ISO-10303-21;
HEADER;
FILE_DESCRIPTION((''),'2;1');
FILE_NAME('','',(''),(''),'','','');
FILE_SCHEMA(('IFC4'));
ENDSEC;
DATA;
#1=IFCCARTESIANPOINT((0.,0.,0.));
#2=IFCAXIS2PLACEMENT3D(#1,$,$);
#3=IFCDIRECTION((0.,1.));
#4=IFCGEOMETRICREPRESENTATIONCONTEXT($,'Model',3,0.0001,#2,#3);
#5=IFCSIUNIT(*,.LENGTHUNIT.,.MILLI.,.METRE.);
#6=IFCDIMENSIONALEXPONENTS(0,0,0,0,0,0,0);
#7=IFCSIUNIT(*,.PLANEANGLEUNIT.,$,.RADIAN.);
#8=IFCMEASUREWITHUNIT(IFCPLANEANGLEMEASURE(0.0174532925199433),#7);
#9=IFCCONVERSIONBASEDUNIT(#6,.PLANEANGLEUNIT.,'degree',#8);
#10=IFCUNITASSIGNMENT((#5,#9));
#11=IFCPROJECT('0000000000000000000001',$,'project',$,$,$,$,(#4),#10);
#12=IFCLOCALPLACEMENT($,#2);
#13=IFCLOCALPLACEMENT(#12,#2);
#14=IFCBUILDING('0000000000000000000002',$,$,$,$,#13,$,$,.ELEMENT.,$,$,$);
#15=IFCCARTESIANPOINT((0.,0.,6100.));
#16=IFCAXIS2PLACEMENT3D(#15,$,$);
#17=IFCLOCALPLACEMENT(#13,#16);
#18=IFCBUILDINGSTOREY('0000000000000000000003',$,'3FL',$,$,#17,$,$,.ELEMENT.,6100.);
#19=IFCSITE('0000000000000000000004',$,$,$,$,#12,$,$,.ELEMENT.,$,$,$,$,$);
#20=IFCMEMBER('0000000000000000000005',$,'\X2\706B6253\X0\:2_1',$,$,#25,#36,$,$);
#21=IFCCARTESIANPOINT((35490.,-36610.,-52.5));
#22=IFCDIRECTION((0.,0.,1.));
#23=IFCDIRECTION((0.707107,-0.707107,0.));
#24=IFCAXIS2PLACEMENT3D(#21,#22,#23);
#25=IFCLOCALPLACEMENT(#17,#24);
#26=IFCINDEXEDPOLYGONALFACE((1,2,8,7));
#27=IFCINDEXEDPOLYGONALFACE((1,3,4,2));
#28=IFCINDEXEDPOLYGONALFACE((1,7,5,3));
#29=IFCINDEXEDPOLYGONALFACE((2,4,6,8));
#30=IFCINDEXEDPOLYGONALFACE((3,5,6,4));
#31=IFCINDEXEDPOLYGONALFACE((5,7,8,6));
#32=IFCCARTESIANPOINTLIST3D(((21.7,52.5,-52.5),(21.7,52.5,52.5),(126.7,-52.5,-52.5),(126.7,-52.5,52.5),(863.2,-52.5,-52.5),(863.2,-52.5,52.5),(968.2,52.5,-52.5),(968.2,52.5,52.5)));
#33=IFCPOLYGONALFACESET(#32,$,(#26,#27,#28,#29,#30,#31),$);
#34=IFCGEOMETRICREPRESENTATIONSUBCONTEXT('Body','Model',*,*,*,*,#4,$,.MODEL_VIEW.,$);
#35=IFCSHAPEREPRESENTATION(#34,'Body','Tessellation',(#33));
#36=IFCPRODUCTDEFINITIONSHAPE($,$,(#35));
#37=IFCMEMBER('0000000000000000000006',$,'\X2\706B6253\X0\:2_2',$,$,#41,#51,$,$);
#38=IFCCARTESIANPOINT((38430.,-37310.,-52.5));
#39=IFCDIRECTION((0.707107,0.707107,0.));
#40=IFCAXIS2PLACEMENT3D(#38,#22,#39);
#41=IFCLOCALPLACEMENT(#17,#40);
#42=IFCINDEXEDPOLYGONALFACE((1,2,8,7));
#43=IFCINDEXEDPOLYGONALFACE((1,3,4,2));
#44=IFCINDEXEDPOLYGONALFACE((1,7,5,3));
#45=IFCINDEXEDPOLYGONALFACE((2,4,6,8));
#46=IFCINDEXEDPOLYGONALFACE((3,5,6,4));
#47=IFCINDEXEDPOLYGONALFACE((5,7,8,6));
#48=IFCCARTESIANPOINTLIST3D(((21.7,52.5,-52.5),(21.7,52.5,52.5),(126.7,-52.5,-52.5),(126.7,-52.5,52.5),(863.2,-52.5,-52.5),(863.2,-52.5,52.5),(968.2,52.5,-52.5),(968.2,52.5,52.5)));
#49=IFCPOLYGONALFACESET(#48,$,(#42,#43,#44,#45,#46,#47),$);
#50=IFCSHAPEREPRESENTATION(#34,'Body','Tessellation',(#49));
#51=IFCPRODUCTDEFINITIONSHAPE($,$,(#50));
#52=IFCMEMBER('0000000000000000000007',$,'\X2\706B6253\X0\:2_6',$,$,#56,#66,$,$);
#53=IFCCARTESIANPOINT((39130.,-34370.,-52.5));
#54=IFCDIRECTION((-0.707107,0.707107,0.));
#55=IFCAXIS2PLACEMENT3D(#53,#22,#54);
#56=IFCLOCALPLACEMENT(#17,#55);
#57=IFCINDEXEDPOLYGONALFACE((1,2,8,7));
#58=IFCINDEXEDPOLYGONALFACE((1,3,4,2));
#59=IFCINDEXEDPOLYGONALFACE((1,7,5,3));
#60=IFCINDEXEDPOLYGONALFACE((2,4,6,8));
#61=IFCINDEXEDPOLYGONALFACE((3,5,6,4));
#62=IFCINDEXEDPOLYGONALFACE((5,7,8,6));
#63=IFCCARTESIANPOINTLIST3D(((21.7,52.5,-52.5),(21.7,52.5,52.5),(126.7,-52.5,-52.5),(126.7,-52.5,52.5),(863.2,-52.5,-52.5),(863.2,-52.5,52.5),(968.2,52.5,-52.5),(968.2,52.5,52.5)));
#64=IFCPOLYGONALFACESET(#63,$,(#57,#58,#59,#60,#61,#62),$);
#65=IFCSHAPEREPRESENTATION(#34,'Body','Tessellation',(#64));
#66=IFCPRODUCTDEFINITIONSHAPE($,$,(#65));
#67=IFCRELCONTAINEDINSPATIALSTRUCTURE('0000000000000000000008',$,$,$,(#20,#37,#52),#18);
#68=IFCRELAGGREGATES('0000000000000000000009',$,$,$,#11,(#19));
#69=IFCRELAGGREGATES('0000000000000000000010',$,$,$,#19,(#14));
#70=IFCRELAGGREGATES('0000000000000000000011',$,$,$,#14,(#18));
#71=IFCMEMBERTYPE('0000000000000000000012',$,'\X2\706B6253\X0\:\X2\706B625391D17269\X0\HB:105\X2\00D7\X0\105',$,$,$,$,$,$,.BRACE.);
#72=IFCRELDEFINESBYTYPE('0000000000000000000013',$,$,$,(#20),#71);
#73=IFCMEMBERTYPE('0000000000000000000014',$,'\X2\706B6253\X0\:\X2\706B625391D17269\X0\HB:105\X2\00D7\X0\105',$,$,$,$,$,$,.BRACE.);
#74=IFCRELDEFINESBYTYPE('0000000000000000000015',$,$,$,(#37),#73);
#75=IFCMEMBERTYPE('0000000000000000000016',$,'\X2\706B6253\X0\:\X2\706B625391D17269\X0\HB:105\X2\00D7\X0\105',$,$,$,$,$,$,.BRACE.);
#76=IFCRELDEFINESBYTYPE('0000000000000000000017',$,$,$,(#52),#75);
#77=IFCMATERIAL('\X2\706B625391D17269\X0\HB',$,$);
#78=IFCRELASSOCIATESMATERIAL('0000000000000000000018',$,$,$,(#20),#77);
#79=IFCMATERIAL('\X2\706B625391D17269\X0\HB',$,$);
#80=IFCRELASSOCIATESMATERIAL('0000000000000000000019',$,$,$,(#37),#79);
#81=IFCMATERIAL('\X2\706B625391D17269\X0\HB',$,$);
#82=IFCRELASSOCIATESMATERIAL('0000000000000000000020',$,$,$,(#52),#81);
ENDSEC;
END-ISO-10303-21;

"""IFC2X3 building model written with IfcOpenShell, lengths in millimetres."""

from ifc_helpers import new_model, entity, si_unit, converted_unit, direction, frame, origin, place, context, subcontext, project, spatial, polyline, outline, extrude, material, type_object, element, save


model = new_model("IFC2X3")

# Units and contexts
model_context = context("Model", 3, precision=0.0001, world=origin(), true_north=direction((0.0, 1.0)))
body_context = subcontext(model_context, "Body", "Model", "MODEL_VIEW")
ifc_project = project(units=[si_unit("LENGTHUNIT", "METRE", prefix="MILLI"), converted_unit("PLANEANGLEUNIT", "degree", entity("IfcPlaneAngleMeasure", 0.0174532925199433), si_unit("PLANEANGLEUNIT", "RADIAN"), dimensions=[0, 0, 0, 0, 0, 0, 0])], contexts=[model_context])

# Site, building, storey
site_placement = place(None, origin())
site = spatial("IfcSite", under=ifc_project, at=site_placement, CompositionType="ELEMENT")
building_placement = place(site_placement, origin())
building = spatial("IfcBuilding", under=site, at=building_placement, CompositionType="ELEMENT")
storey_placement = place(building_placement, frame((0.0, 0.0, 6100.0)))
storey = spatial("IfcBuildingStorey", under=building, at=storey_placement, Name="3FL", CompositionType="ELEMENT", Elevation=6100.0)

# Members
ifc_material_1 = material(Name="火打金物HB")
member_type_1 = type_object("IfcMemberType", Name="火打:火打金物HB:105×105", PredefinedType="BRACE")
member_1_placement = place(storey_placement, frame((35490.0, -36610.0, -52.5), z_axis=(0.0, 0.0, 1.0), x_axis=(0.707107, -0.707107, 0.0)))
element("IfcMember", 1, at=member_1_placement, inside=storey, type_object=member_type_1, material=ifc_material_1, Name="火打:2_1", context=body_context, shape_type="SweptSolid", body=[
    extrude(outline(polyline([(126.7, -52.5, 0.0), (21.7, 52.5, 0.0), (968.2, 52.5, 0.0), (863.2, -52.5, 0.0), (126.7, -52.5, 0.0)])), frame((0.0, 0.0, -52.5), z_axis=(0.0, 0.0, 1.0), x_axis=(1.0, 0.0, 0.0)), (0.0, 0.0, 1.0), 105.0),
])
ifc_material_2 = material(Name="火打金物HB")
member_type_2 = type_object("IfcMemberType", Name="火打:火打金物HB:105×105", PredefinedType="BRACE")
member_2_placement = place(storey_placement, frame((38430.0, -37310.0, -52.5), z_axis=(0.0, 0.0, 1.0), x_axis=(0.707107, 0.707107, 0.0)))
element("IfcMember", 2, at=member_2_placement, inside=storey, type_object=member_type_2, material=ifc_material_2, Name="火打:2_2", context=body_context, shape_type="SweptSolid", body=[
    extrude(outline(polyline([(126.7, -52.5, 0.0), (21.7, 52.5, 0.0), (968.2, 52.5, 0.0), (863.2, -52.5, 0.0), (126.7, -52.5, 0.0)])), frame((0.0, 0.0, -52.5), z_axis=(0.0, 0.0, 1.0), x_axis=(1.0, 0.0, 0.0)), (0.0, 0.0, 1.0), 105.0),
])
ifc_material_3 = material(Name="火打金物HB")
member_type_3 = type_object("IfcMemberType", Name="火打:火打金物HB:105×105", PredefinedType="BRACE")
member_3_placement = place(storey_placement, frame((39130.0, -34370.0, -52.5), z_axis=(0.0, 0.0, 1.0), x_axis=(-0.707107, 0.707107, 0.0)))
element("IfcMember", 3, at=member_3_placement, inside=storey, type_object=member_type_3, material=ifc_material_3, Name="火打:2_6", context=body_context, shape_type="SweptSolid", body=[
    extrude(outline(polyline([(126.7, -52.5, 0.0), (21.7, 52.5, 0.0), (968.2, 52.5, 0.0), (863.2, -52.5, 0.0), (126.7, -52.5, 0.0)])), frame((0.0, 0.0, -52.5), z_axis=(0.0, 0.0, 1.0), x_axis=(1.0, 0.0, 0.0)), (0.0, 0.0, 1.0), 105.0),
])

save(model, "model.ifc")
